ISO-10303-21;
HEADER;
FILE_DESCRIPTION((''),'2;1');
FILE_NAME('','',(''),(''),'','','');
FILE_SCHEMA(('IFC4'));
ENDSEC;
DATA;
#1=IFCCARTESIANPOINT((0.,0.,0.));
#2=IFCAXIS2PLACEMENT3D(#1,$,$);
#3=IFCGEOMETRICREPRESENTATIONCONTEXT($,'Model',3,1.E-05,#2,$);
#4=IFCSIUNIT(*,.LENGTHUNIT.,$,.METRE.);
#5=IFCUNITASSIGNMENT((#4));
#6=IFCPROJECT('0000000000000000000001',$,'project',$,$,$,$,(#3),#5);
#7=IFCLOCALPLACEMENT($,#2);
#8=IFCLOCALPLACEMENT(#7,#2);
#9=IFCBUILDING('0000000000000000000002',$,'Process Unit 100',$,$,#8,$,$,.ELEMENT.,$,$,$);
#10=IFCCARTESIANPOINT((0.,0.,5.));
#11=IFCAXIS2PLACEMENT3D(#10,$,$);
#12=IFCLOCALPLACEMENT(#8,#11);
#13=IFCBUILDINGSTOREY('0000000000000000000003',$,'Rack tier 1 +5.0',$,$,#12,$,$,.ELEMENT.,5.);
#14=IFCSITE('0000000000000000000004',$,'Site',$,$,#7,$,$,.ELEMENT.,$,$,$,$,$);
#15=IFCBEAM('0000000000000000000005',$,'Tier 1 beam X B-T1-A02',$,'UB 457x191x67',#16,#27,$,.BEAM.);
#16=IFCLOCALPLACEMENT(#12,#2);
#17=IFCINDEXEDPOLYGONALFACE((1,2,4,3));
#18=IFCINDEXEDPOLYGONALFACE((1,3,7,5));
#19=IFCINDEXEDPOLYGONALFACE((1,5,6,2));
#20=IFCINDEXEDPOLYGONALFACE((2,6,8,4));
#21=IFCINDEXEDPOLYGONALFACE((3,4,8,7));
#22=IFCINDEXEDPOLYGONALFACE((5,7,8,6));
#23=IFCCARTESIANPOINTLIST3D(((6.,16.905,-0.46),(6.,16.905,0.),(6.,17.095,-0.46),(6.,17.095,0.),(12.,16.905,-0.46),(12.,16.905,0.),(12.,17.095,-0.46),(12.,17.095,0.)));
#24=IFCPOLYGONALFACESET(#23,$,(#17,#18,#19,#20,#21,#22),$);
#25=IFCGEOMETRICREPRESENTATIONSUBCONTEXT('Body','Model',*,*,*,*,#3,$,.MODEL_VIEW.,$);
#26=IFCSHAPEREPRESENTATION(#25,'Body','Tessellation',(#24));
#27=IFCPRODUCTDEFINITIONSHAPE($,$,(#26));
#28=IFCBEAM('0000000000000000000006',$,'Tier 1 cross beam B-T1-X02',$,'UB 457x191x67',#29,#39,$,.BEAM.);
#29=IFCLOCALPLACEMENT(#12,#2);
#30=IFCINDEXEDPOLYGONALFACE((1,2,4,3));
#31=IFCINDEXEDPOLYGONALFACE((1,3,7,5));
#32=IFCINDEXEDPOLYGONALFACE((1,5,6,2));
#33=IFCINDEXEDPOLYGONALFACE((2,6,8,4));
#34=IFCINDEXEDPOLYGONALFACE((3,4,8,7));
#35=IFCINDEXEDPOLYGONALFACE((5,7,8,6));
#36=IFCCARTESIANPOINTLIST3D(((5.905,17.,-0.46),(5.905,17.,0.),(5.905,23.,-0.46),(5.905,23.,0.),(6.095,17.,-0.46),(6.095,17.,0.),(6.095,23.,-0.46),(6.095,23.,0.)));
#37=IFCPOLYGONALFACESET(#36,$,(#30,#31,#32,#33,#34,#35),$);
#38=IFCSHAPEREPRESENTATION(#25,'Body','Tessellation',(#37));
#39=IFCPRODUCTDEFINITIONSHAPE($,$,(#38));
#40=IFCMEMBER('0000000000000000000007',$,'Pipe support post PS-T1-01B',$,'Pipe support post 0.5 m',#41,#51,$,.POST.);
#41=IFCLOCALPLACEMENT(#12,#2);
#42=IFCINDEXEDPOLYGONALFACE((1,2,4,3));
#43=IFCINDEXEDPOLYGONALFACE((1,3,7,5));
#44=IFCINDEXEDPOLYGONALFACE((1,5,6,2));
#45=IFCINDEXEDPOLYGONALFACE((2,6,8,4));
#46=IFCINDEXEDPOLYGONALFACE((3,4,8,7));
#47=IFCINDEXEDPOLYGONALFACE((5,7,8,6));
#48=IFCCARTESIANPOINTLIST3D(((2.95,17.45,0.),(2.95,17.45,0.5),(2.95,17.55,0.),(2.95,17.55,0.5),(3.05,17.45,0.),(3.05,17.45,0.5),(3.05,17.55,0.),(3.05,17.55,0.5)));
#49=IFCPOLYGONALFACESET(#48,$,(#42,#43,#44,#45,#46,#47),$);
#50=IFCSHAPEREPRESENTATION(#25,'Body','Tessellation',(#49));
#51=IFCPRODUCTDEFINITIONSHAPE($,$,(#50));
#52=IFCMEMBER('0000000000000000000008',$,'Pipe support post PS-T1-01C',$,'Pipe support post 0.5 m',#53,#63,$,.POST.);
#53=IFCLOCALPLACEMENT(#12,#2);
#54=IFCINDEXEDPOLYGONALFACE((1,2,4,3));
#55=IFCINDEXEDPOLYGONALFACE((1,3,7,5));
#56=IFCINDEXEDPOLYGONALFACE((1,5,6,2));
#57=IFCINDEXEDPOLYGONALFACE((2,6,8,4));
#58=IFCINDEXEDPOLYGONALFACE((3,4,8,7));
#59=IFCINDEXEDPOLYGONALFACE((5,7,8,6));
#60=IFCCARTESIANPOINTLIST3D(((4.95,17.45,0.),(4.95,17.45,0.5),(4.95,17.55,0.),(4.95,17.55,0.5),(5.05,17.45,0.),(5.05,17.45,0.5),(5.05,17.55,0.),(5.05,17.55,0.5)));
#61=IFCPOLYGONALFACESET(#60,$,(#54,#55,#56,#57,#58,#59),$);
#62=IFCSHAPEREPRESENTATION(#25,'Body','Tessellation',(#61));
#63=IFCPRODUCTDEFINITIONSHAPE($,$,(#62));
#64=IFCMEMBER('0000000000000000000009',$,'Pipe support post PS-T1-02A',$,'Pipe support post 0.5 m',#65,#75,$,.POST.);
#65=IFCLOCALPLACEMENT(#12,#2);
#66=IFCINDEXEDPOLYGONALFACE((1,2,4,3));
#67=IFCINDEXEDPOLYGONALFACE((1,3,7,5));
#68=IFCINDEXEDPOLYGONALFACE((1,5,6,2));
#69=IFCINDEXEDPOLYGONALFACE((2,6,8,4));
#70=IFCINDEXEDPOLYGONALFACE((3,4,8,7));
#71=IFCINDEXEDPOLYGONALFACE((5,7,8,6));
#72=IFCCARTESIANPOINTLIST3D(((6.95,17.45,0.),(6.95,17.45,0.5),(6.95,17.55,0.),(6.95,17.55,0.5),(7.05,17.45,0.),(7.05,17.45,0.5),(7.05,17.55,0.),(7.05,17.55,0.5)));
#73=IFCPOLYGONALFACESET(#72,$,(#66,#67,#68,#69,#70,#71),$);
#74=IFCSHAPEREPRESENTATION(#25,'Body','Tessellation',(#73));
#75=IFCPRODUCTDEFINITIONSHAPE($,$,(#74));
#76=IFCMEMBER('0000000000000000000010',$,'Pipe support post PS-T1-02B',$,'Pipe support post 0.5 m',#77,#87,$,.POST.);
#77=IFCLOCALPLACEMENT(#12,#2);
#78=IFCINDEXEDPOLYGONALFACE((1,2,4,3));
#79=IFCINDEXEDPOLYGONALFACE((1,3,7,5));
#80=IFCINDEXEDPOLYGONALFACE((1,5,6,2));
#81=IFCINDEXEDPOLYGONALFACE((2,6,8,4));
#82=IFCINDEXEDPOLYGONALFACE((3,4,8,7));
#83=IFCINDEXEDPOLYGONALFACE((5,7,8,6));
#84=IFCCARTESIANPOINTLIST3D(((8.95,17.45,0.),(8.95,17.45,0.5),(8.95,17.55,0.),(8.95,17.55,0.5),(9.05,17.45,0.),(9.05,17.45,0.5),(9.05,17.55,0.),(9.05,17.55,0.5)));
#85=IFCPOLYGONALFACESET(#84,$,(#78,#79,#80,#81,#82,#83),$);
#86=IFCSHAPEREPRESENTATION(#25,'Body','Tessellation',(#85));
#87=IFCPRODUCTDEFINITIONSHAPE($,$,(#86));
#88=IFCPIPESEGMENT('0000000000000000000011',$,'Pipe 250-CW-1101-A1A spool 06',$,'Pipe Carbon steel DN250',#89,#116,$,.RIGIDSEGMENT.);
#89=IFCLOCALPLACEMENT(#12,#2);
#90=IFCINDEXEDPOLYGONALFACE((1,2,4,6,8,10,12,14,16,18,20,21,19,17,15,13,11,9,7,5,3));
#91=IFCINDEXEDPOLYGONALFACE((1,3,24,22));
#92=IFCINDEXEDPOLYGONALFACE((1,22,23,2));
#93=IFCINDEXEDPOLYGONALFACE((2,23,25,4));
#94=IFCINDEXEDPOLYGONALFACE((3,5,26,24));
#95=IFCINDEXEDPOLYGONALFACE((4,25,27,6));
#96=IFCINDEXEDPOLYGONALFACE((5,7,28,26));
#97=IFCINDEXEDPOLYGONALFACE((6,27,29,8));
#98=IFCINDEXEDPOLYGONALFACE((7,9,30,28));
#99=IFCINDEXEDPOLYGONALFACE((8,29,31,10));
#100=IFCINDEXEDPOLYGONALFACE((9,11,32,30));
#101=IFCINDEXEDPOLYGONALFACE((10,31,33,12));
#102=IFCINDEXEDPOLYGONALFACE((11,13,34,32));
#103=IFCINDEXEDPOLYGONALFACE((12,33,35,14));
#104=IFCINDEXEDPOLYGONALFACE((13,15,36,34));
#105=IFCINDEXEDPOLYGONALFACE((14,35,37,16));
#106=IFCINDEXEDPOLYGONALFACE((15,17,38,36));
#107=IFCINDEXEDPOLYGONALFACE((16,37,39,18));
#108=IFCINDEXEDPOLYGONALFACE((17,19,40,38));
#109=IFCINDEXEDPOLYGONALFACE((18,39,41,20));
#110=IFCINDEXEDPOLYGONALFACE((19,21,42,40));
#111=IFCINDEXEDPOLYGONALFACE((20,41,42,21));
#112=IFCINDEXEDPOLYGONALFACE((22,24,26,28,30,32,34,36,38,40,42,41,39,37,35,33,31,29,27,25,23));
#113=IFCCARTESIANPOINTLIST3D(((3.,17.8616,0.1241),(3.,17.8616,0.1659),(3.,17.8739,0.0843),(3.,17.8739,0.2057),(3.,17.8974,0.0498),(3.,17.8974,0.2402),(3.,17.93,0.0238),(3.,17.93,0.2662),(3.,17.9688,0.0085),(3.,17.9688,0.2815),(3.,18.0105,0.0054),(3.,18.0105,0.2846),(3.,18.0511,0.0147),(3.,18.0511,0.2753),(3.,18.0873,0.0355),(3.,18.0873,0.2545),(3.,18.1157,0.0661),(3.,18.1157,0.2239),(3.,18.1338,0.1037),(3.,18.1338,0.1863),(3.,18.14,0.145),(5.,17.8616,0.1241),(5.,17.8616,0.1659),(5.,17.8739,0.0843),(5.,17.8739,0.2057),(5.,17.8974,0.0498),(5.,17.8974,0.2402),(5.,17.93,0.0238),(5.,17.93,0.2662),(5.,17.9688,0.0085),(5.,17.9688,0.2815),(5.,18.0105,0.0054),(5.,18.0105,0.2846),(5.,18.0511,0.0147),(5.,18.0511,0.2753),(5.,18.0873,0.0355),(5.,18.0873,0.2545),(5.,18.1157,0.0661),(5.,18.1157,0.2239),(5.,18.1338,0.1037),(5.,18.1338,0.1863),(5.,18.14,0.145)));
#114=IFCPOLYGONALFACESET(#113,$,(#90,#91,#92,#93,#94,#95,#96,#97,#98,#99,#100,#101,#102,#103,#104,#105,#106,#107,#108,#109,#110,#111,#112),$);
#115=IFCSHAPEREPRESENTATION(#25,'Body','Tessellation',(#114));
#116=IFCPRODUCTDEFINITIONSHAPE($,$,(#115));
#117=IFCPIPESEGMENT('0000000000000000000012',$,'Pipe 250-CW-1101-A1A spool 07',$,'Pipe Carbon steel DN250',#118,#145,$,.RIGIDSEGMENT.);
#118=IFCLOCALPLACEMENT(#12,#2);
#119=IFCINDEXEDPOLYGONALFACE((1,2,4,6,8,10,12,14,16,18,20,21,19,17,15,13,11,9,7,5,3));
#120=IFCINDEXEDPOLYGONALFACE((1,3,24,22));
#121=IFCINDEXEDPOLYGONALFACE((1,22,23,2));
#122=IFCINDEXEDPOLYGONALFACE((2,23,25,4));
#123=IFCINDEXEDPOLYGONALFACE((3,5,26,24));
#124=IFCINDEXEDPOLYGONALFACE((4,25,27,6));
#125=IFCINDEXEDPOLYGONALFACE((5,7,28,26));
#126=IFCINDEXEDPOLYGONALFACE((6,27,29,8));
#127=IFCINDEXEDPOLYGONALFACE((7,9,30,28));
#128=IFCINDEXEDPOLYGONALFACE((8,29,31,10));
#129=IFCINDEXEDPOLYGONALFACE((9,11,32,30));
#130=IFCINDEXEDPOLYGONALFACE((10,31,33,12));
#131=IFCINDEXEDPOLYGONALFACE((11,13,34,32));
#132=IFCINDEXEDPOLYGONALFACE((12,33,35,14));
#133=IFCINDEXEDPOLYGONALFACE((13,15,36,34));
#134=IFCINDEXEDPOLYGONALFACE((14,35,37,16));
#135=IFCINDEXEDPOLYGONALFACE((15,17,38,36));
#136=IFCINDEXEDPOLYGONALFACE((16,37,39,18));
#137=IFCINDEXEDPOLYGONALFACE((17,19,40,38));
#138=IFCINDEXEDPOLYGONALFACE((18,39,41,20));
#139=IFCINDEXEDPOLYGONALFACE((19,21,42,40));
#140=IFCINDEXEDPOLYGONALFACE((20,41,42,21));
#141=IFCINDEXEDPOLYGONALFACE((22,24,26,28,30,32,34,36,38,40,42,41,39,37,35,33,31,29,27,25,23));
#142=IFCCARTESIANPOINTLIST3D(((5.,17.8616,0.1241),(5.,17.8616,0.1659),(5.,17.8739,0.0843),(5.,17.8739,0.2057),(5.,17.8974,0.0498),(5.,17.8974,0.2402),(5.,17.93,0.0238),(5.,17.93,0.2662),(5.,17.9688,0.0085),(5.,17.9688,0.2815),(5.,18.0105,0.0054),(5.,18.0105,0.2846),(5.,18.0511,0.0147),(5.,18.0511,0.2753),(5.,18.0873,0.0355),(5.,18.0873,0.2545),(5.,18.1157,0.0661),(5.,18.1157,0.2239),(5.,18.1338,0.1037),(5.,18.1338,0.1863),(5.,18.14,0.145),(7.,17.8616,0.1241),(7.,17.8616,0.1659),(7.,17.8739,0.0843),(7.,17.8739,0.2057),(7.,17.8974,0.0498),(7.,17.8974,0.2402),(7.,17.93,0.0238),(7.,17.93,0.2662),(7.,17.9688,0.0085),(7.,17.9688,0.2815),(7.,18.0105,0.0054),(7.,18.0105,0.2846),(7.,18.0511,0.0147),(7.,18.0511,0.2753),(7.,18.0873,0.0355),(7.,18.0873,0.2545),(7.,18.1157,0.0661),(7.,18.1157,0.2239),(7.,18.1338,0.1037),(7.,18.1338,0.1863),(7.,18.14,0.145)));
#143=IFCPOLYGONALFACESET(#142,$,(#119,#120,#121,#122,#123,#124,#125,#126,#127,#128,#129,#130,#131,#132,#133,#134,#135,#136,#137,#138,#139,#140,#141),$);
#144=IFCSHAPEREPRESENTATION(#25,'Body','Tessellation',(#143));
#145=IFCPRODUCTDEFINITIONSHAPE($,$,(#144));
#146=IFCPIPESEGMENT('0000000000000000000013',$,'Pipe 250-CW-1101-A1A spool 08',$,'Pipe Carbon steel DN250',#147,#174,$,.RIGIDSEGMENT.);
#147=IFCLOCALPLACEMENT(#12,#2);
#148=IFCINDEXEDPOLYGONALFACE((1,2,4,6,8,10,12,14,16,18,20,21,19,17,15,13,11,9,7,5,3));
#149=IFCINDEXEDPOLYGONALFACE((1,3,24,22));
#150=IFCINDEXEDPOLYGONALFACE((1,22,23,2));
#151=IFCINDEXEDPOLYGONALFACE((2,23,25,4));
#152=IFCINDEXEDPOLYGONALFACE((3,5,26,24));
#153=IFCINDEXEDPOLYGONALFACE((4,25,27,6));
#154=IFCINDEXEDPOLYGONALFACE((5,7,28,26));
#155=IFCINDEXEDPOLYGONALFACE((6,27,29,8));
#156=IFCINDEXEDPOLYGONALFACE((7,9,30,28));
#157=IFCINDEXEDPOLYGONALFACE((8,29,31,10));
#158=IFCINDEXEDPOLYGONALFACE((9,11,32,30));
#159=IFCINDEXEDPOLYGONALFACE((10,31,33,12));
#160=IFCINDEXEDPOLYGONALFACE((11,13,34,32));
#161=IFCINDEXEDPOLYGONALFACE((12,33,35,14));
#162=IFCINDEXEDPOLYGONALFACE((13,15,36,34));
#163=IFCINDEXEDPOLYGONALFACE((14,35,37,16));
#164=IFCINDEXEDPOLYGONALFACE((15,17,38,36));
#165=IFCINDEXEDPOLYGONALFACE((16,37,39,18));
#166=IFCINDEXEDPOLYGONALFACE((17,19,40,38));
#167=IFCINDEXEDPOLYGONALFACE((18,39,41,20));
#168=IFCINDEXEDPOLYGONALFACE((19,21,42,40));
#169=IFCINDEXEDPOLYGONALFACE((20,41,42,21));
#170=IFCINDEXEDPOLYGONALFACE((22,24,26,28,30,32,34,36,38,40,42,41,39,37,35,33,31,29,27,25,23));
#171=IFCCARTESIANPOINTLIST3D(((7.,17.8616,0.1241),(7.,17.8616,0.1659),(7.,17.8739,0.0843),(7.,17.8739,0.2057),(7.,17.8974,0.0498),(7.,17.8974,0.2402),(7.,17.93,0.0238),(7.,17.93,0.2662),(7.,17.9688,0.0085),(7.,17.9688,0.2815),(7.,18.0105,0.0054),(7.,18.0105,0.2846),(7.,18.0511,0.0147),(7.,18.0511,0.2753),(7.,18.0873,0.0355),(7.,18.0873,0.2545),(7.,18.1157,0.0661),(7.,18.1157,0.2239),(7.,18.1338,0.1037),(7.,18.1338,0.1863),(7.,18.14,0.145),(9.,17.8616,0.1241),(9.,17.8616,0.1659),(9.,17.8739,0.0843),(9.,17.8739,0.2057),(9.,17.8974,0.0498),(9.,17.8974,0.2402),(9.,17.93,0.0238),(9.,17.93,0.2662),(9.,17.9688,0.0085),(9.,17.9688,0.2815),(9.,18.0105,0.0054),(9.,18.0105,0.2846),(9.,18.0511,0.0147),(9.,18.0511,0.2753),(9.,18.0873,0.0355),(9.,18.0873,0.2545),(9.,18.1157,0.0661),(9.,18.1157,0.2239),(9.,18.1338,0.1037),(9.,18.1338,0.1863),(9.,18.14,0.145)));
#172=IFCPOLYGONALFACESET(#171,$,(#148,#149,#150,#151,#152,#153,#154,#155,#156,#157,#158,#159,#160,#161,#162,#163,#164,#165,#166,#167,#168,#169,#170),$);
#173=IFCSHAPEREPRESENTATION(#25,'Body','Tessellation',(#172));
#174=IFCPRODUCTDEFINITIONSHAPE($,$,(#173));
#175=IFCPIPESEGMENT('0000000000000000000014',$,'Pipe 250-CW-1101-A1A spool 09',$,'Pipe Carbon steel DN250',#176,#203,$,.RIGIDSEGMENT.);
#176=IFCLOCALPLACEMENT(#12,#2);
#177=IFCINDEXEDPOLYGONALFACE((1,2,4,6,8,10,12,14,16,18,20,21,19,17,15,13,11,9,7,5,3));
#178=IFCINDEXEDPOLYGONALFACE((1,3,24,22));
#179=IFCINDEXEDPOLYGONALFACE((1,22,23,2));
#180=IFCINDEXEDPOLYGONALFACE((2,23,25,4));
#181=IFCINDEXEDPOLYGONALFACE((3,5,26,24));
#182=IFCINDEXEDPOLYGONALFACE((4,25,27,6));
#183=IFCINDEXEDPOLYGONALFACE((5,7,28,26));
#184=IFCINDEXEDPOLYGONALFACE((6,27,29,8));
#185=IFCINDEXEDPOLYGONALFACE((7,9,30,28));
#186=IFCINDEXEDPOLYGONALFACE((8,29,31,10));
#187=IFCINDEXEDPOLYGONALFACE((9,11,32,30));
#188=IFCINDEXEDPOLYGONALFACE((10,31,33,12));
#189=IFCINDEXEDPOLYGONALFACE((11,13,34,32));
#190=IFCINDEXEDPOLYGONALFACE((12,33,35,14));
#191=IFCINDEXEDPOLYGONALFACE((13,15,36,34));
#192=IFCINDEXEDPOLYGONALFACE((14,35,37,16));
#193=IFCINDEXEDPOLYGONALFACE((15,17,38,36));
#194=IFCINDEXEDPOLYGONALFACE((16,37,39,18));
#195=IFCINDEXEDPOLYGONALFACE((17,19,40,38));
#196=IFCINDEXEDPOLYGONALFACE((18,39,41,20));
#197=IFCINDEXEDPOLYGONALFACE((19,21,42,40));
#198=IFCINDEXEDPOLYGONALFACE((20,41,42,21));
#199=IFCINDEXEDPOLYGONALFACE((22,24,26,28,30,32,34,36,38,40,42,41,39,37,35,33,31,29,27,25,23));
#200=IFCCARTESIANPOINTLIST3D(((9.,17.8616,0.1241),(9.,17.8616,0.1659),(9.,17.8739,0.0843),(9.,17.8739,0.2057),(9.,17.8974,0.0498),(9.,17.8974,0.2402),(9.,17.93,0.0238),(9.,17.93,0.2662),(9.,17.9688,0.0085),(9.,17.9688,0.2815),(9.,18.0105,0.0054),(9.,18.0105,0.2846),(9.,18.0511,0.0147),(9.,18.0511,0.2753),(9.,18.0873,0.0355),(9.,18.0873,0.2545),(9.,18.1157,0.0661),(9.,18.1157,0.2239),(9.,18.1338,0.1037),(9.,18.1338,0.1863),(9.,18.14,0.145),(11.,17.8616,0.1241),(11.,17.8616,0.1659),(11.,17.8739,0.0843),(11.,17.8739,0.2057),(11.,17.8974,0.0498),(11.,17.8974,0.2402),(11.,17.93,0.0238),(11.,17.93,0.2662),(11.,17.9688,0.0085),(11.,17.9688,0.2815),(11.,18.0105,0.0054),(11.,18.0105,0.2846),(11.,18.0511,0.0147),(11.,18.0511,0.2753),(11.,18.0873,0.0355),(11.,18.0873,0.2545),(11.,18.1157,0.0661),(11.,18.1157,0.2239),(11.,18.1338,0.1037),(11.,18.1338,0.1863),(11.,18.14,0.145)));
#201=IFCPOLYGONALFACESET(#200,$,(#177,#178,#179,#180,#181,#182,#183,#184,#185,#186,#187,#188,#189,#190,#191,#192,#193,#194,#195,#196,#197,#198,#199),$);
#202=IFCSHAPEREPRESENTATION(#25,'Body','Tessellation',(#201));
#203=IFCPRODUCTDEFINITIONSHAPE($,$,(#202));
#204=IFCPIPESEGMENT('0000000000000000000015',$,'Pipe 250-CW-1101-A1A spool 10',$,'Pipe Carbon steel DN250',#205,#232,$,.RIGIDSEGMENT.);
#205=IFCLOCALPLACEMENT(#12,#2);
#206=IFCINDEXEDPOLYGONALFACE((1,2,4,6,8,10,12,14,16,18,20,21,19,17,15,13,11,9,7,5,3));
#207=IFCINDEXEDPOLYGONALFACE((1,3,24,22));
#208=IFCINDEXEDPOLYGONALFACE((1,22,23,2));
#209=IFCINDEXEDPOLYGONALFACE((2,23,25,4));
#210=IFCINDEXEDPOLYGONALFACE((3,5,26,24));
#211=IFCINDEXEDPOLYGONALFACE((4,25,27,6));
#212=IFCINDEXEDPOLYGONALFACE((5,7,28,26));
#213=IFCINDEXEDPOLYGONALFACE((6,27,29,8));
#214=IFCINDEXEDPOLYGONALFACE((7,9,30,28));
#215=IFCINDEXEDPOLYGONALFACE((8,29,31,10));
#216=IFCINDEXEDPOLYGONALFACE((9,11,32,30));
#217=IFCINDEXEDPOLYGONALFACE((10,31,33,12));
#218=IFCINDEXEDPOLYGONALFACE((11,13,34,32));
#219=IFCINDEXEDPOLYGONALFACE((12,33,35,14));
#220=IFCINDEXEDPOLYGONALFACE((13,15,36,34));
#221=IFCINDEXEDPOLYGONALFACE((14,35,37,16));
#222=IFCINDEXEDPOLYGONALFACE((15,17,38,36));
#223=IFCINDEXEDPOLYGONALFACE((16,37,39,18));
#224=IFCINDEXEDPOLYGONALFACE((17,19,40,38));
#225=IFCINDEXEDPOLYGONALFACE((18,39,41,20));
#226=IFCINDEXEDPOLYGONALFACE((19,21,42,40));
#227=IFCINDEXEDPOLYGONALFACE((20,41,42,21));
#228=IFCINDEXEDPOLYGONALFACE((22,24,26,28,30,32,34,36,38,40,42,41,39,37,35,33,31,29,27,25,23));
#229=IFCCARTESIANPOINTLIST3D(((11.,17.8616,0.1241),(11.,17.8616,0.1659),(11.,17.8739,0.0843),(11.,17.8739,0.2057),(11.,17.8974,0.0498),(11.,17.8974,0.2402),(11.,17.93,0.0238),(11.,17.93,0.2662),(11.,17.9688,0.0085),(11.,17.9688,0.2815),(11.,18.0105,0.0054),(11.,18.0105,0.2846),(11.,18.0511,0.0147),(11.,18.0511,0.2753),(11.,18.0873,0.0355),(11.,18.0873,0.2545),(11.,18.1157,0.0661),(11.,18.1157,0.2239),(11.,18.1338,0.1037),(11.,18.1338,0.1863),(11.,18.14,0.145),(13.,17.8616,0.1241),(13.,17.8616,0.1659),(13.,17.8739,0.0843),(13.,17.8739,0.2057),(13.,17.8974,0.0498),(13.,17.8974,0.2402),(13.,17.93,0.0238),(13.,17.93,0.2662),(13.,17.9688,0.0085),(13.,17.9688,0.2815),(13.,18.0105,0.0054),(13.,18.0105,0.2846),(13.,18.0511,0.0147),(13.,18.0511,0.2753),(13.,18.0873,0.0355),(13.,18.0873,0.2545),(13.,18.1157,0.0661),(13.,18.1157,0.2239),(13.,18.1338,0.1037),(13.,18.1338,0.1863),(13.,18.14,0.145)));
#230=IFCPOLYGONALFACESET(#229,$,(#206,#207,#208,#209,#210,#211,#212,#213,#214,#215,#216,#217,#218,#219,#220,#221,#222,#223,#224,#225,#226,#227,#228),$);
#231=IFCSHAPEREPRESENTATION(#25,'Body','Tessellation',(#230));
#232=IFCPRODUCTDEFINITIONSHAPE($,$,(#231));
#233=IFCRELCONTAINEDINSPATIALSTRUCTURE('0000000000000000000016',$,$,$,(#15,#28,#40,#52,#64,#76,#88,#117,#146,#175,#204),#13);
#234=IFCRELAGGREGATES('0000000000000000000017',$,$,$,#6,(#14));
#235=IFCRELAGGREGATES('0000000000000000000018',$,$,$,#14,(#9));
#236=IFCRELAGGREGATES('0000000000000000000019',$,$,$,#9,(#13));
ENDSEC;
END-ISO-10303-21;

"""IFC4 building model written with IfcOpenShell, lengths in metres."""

from ifc_helpers import new_model, si_unit, frame, origin, place, context, subcontext, project, spatial, rectangle, circle, extrude, element, save


model = new_model("IFC4")

# Units and contexts
model_context = context("Model", 3, precision=1e-05, world=origin())
body_context = subcontext(model_context, "Body", "Model", "MODEL_VIEW")
ifc_project = project(units=[si_unit("LENGTHUNIT", "METRE")], contexts=[model_context])

# Site, building, storey
site_placement = place(None, origin())
site = spatial("IfcSite", under=ifc_project, at=site_placement, Name="Site", CompositionType="ELEMENT")
building_placement = place(site_placement, origin())
building = spatial("IfcBuilding", under=site, at=building_placement, Name="Process Unit 100", CompositionType="ELEMENT")
storey_placement = place(building_placement, frame((0.0, 0.0, 5.0)))
storey = spatial("IfcBuildingStorey", under=building, at=storey_placement, Name="Rack tier 1 +5.0", CompositionType="ELEMENT", Elevation=5.0)

# Beams
for number, where, z_axis, x_axis, name in (
    (1, (6.0, 17.0, -0.23), (1.0, 0.0, 0.0), (0.0, 1.0, 0.0), "Tier 1 beam X B-T1-A02"),
    (2, (6.0, 17.0, -0.23), (0.0, 1.0, 0.0), (-1.0, 0.0, 0.0), "Tier 1 cross beam B-T1-X02"),
):
    element("IfcBeam", number, at=place(storey_placement, frame(where, z_axis=z_axis, x_axis=x_axis)), inside=storey, Name=name, ObjectType="UB 457x191x67", PredefinedType="BEAM", context=body_context, shape_type="SweptSolid", body=[
        extrude(rectangle(XDim=0.19, YDim=0.46), origin(), (0.0, 0.0, 1.0), 6.0),
    ])

# Members
for number, where, z_axis, x_axis, name in (
    (3, (3.0, 17.5, 0.0), (0.0, 0.0, 1.0), (1.0, 0.0, 0.0), "Pipe support post PS-T1-01B"),
    (4, (5.0, 17.5, 0.0), (0.0, 0.0, 1.0), (1.0, 0.0, 0.0), "Pipe support post PS-T1-01C"),
    (5, (7.0, 17.5, 0.0), (0.0, 0.0, 1.0), (1.0, 0.0, 0.0), "Pipe support post PS-T1-02A"),
    (6, (9.0, 17.5, 0.0), (0.0, 0.0, 1.0), (1.0, 0.0, 0.0), "Pipe support post PS-T1-02B"),
):
    element("IfcMember", number, at=place(storey_placement, frame(where, z_axis=z_axis, x_axis=x_axis)), inside=storey, Name=name, ObjectType="Pipe support post 0.5 m", PredefinedType="POST", context=body_context, shape_type="SweptSolid", body=[
        extrude(rectangle(XDim=0.1, YDim=0.1), origin(), (0.0, 0.0, 1.0), 0.5),
    ])

# Pipe segments
for number, where, z_axis, x_axis, name in (
    (7, (3.0, 18.0, 0.145), (1.0, 0.0, 0.0), (0.0, 1.0, 0.0), "Pipe 250-CW-1101-A1A spool 06"),
    (8, (5.0, 18.0, 0.145), (1.0, 0.0, 0.0), (0.0, 1.0, 0.0), "Pipe 250-CW-1101-A1A spool 07"),
    (9, (7.0, 18.0, 0.145), (1.0, 0.0, 0.0), (0.0, 1.0, 0.0), "Pipe 250-CW-1101-A1A spool 08"),
    (10, (9.0, 18.0, 0.145), (1.0, 0.0, 0.0), (0.0, 1.0, 0.0), "Pipe 250-CW-1101-A1A spool 09"),
    (11, (11.0, 18.0, 0.145), (1.0, 0.0, 0.0), (0.0, 1.0, 0.0), "Pipe 250-CW-1101-A1A spool 10"),
):
    element("IfcPipeSegment", number, at=place(storey_placement, frame(where, z_axis=z_axis, x_axis=x_axis)), inside=storey, Name=name, ObjectType="Pipe Carbon steel DN250", PredefinedType="RIGIDSEGMENT", context=body_context, shape_type="SweptSolid", body=[
        extrude(circle(Radius=0.14), origin(), (0.0, 0.0, 1.0), 2.0),
    ])

save(model, "model.ifc")
